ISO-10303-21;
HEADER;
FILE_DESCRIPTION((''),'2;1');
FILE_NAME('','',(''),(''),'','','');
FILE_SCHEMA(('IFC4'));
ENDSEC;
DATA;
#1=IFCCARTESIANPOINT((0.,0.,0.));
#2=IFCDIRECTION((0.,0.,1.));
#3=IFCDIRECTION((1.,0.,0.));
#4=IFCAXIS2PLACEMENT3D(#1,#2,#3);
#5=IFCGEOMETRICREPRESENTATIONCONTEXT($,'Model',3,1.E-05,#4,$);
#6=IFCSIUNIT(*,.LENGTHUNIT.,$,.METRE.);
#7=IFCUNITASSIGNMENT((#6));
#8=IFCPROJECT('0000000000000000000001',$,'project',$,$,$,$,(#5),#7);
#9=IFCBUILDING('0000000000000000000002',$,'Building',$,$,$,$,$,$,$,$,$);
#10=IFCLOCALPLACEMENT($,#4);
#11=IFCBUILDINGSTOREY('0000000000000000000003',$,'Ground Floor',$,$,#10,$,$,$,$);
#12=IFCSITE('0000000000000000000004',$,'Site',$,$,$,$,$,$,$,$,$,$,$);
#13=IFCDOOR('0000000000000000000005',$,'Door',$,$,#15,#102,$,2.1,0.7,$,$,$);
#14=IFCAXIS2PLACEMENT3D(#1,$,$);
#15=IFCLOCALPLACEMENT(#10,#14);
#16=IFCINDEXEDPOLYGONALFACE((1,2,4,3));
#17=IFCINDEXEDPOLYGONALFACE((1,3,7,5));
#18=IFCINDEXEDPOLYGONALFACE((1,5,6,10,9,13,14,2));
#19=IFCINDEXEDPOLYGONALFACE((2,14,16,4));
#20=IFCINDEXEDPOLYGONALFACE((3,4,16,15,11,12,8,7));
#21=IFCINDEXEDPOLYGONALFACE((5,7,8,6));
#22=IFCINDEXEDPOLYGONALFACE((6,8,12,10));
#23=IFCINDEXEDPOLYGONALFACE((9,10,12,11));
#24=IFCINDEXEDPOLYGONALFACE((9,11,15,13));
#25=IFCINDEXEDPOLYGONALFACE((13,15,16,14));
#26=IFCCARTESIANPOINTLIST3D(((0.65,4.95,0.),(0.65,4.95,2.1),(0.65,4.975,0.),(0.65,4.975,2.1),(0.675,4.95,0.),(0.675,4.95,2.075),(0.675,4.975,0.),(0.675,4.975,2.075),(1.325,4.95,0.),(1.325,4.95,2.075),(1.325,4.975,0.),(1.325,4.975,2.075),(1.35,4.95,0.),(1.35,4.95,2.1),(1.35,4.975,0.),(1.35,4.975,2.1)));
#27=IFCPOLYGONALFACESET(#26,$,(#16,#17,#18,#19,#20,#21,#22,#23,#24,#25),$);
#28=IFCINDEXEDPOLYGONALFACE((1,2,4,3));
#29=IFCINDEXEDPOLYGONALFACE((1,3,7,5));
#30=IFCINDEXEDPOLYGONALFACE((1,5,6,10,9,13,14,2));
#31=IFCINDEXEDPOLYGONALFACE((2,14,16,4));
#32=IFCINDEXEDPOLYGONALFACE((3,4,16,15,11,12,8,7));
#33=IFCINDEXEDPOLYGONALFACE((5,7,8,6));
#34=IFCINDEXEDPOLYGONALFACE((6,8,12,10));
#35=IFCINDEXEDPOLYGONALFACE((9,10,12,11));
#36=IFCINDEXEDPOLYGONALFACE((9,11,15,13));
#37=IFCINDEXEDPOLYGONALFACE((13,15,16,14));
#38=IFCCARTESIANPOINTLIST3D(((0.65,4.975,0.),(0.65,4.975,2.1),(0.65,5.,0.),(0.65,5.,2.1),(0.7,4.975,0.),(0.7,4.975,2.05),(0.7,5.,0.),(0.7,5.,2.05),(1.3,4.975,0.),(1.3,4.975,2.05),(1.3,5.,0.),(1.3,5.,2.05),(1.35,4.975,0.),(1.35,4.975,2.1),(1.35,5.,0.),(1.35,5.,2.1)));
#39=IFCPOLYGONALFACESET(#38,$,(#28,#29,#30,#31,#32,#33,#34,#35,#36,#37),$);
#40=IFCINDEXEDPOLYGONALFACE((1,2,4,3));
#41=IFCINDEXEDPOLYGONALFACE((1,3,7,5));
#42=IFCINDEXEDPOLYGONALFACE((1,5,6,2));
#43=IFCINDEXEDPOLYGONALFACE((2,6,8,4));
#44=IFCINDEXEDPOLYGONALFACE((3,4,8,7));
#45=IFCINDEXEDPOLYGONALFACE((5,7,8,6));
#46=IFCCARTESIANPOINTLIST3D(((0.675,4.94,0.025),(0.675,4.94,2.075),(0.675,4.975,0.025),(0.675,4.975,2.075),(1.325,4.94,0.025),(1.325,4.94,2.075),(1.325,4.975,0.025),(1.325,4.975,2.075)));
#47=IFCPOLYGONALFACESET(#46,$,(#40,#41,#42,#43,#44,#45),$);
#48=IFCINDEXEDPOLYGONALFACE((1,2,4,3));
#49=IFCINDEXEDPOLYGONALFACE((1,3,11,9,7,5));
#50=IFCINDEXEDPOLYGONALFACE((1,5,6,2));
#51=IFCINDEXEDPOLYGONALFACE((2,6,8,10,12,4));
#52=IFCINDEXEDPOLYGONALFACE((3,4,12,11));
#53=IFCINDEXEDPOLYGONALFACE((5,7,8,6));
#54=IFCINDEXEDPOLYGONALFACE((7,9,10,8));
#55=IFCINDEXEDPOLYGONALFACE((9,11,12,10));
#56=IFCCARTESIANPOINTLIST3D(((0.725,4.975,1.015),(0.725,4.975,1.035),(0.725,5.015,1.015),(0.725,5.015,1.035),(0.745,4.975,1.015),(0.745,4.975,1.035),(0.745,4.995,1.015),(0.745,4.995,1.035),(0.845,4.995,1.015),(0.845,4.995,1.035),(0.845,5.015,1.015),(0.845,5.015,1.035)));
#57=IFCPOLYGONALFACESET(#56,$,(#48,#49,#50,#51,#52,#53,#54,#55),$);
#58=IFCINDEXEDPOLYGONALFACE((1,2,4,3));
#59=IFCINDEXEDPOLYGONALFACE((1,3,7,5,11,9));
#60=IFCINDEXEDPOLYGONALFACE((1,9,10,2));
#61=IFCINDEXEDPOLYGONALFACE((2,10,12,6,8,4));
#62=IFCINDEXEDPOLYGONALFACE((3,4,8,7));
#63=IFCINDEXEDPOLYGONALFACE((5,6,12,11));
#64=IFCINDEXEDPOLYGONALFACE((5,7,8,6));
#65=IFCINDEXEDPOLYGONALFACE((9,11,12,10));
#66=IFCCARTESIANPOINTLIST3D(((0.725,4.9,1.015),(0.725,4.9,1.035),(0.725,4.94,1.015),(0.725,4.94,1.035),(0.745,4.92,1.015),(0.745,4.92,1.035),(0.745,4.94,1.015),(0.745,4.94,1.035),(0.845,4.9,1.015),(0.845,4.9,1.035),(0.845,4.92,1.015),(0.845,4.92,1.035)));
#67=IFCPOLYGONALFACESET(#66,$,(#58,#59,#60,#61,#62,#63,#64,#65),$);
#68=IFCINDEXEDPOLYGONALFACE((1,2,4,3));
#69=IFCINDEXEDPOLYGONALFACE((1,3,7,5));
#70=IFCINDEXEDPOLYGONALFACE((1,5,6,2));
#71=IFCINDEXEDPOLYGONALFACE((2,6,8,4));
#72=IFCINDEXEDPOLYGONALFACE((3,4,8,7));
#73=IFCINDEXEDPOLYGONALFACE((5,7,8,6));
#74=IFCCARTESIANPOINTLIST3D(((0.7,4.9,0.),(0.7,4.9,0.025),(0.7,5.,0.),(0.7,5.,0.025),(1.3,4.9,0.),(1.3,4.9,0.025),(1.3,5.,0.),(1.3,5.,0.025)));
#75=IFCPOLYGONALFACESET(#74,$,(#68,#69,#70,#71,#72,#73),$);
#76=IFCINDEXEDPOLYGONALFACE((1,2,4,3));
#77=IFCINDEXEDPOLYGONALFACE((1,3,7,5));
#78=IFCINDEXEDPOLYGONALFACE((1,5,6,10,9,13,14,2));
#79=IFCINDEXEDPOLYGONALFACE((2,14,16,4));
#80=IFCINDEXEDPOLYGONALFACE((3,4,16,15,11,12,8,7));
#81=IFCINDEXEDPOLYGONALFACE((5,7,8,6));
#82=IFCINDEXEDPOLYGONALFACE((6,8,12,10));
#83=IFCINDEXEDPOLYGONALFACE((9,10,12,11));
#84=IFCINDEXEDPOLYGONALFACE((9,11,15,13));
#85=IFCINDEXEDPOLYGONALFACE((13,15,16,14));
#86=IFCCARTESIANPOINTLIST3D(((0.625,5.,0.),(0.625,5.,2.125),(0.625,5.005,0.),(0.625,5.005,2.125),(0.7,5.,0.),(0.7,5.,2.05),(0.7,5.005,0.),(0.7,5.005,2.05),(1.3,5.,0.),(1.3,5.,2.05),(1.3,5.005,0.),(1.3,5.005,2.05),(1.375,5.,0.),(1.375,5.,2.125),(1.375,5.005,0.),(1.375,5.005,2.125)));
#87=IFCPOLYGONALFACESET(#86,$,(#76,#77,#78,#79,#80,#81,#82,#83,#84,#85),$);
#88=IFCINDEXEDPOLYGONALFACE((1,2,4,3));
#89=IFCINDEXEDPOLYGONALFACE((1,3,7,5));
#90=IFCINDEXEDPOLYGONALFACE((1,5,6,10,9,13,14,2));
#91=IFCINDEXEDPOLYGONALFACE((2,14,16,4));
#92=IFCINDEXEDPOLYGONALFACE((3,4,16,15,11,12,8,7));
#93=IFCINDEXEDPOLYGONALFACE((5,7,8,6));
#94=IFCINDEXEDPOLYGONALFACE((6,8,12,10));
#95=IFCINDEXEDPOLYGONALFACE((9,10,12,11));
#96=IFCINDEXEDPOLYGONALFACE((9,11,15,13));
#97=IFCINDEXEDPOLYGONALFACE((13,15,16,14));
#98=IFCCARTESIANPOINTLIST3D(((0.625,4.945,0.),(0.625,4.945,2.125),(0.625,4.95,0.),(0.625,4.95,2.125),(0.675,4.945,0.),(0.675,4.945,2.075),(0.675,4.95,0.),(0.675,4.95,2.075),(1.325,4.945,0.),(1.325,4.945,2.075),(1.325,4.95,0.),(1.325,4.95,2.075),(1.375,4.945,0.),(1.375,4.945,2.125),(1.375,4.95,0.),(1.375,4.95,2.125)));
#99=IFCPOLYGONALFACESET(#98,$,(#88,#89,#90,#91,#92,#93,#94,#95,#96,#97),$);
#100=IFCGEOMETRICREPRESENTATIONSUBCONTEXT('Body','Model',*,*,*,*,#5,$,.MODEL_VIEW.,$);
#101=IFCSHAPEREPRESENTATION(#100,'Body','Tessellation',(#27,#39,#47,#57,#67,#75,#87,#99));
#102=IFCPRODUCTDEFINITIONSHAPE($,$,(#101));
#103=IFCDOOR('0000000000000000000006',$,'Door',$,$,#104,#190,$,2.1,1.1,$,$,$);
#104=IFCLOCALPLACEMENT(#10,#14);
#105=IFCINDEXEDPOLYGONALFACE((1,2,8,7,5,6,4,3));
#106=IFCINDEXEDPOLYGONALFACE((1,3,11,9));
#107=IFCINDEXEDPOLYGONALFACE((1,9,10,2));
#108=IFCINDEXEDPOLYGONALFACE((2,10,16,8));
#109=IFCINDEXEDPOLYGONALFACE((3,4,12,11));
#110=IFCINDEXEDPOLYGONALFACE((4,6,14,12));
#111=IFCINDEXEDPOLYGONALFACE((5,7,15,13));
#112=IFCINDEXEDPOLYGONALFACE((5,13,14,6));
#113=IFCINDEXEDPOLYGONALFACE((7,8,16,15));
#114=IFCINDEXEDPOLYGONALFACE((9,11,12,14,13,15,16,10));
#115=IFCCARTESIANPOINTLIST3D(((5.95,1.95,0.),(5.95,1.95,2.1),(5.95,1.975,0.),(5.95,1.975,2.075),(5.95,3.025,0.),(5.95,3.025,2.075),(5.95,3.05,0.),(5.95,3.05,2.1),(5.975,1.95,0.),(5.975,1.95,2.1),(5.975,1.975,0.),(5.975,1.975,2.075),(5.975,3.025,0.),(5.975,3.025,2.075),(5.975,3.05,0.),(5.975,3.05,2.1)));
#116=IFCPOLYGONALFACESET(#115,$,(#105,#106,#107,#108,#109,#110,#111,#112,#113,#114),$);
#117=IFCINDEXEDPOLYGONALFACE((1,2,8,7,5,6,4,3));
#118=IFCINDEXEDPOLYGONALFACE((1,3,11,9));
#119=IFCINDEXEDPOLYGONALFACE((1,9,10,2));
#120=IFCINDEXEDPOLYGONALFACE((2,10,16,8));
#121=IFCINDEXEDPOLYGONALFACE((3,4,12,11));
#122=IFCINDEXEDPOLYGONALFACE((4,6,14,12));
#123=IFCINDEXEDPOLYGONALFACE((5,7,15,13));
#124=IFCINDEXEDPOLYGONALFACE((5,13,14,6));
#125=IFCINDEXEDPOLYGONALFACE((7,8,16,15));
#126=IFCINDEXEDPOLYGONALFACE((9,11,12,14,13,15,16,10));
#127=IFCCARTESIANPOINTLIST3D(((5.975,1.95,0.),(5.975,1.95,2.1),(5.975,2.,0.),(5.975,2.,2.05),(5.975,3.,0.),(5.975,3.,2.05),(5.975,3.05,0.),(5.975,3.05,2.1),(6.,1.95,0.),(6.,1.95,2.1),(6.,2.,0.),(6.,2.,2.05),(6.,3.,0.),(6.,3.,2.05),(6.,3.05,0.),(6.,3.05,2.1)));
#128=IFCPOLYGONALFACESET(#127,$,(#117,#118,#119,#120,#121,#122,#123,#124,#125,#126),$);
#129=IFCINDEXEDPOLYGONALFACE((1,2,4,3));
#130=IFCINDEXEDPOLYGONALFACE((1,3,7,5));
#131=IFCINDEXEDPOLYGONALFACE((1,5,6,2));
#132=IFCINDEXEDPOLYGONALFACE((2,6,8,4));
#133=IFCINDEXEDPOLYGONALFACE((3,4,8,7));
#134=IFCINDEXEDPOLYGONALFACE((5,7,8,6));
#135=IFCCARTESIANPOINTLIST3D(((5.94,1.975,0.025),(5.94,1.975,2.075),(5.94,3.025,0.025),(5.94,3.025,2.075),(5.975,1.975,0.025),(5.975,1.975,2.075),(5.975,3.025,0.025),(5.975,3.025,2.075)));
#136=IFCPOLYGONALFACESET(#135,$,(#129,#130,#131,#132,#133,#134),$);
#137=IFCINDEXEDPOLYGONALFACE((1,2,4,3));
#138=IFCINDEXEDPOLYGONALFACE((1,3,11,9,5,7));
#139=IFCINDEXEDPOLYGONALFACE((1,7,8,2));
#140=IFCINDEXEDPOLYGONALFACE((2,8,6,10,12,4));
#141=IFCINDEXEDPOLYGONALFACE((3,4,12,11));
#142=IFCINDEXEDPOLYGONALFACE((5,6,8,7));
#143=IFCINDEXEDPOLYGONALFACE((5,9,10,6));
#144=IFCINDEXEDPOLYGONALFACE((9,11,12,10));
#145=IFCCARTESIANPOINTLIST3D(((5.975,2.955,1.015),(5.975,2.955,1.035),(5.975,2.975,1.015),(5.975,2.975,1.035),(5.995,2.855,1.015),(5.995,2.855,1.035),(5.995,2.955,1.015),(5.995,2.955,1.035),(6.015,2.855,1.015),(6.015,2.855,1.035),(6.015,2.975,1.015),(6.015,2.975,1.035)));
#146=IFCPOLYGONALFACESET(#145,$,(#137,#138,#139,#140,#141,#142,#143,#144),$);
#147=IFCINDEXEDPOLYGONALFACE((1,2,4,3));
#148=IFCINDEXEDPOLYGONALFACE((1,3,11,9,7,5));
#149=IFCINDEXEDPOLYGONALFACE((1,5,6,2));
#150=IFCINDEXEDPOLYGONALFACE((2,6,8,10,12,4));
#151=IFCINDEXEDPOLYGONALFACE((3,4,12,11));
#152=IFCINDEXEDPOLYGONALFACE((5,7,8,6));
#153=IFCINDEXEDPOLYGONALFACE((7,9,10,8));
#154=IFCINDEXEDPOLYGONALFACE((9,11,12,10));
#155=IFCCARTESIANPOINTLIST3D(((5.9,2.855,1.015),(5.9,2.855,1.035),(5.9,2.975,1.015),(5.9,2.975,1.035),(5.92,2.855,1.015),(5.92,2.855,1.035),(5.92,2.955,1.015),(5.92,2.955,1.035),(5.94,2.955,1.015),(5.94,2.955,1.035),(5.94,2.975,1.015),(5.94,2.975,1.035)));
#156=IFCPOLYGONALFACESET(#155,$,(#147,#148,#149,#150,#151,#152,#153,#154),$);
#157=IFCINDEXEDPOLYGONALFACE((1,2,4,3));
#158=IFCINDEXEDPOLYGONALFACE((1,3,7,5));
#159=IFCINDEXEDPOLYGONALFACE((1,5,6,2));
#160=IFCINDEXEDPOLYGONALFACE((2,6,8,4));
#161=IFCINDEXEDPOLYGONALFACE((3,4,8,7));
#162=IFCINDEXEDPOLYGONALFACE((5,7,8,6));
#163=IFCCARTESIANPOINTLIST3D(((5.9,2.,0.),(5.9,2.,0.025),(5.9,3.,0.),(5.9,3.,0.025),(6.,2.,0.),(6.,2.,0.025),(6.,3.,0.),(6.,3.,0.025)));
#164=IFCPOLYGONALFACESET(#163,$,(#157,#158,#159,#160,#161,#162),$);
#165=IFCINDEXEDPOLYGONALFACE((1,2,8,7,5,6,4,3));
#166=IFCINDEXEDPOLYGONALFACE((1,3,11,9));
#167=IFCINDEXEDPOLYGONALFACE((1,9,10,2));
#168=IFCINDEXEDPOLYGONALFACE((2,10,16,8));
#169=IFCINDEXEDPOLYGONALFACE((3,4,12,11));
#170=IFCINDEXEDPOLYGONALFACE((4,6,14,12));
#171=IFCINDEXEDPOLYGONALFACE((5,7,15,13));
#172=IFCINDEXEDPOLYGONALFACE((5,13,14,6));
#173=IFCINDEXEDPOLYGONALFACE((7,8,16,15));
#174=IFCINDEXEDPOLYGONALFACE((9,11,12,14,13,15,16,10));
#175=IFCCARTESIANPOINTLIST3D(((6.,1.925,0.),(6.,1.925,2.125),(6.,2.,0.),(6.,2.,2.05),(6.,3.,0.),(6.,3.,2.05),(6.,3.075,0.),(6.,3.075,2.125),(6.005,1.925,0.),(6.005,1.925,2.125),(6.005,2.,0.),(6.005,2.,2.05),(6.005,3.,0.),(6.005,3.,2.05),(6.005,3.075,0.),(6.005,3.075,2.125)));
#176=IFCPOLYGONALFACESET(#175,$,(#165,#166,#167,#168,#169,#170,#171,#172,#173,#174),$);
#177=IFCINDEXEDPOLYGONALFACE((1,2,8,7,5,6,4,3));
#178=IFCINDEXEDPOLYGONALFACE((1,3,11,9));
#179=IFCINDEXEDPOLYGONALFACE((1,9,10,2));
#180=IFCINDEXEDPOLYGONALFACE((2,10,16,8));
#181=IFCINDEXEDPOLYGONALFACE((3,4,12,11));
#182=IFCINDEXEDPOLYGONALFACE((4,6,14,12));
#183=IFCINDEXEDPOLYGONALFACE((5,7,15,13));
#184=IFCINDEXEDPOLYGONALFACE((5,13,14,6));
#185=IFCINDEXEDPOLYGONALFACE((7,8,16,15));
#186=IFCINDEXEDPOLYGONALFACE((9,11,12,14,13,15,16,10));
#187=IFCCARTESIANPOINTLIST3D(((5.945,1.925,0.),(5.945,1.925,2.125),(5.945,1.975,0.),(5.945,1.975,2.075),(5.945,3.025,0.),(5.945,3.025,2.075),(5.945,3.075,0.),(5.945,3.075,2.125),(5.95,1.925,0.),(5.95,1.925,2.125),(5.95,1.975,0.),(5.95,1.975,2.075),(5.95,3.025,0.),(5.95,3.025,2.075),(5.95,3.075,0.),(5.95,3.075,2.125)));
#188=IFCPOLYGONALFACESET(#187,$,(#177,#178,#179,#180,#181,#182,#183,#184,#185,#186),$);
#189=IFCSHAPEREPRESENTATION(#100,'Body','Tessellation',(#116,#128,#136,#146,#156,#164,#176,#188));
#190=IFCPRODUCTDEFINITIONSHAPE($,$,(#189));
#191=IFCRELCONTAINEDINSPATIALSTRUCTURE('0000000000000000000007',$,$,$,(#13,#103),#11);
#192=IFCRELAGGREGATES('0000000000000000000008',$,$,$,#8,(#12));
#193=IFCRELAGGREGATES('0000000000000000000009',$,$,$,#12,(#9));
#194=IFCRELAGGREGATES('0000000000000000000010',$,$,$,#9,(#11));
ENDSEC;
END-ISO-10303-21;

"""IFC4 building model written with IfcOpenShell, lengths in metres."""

from ifc_helpers import new_model, si_unit, frame, origin_with_axes, place, context, subcontext, project, spatial, line, indexed_curve, outline, extrude, element, save


model = new_model("IFC4")

# Units and contexts
model_context = context("Model", 3, precision=1e-05, world=origin_with_axes())
body_context = subcontext(model_context, "Body", "Model", "MODEL_VIEW")
ifc_project = project(units=[si_unit("LENGTHUNIT", "METRE")], contexts=[model_context])

# Site, building, storey
site = spatial("IfcSite", under=ifc_project, Name="Site")
building = spatial("IfcBuilding", under=site, Name="Building")
storey_placement = place(None, origin_with_axes())
storey = spatial("IfcBuildingStorey", under=building, at=storey_placement, Name="Ground Floor")

# Doors
door_1_placement = place(storey_placement, frame((1.35, 5.0, 0.0), z_axis=(0.0, 0.0, 1.0), x_axis=(-1.0, 0.0, 0.0)))
element("IfcDoor", 1, at=door_1_placement, inside=storey, Name="Door", OverallHeight=2.1, OverallWidth=0.7, context=body_context, shape_type="SweptSolid", body=[
    extrude(outline(indexed_curve([(0.0, 0.0), (0.0, 2.1), (0.7, 2.1), (0.7, 0.0), (0.675, 0.0), (0.675, 2.075), (0.025, 2.075), (0.025, 0.0)], segments=[line(1, 2, 3, 4, 5, 6, 7, 8, 1)])), frame((0.0, 0.025, 0.0), z_axis=(0.0, -1.0, 0.0), x_axis=(1.0, 0.0, 0.0)), (0.0, 0.0, -1.0), 0.025),
    extrude(outline(indexed_curve([(0.0, 0.0), (0.0, 2.1), (0.7, 2.1), (0.7, 0.0), (0.65, 0.0), (0.65, 2.05), (0.05, 2.05), (0.05, 0.0)], segments=[line(1, 2, 3, 4, 5, 6, 7, 8, 1)])), frame((0.0, 0.0, 0.0), z_axis=(0.0, -1.0, 0.0), x_axis=(1.0, 0.0, 0.0)), (0.0, 0.0, -1.0), 0.025),
    extrude(outline(indexed_curve([(0.0, 0.0), (0.65, 0.0), (0.65, 0.035), (0.0, 0.035)], segments=[line(1, 2, 3, 4, 1)])), frame((0.025, 0.025, 0.025), z_axis=(0.0, 0.0, 1.0), x_axis=(1.0, 0.0, 0.0)), (0.0, 0.0, 1.0), 2.05),
    extrude(outline(indexed_curve([(0.0, 0.0), (0.0, -0.04), (-0.12, -0.04), (-0.12, -0.02), (-0.02, -0.02), (-0.02, 0.0)], segments=[line(1, 2, 3, 4, 5, 6, 1)])), frame((0.625, 0.025, 1.015), z_axis=(0.0, 0.0, 1.0), x_axis=(1.0, 0.0, 0.0)), (0.0, 0.0, 1.0), 0.02),
    extrude(outline(indexed_curve([(0.0, 0.0), (0.0, 0.04), (-0.12, 0.04), (-0.12, 0.02), (-0.02, 0.02), (-0.02, 0.0)], segments=[line(1, 2, 3, 4, 5, 6, 1)])), frame((0.625, 0.06, 1.015), z_axis=(0.0, 0.0, 1.0), x_axis=(1.0, 0.0, 0.0)), (0.0, 0.0, 1.0), 0.02),
    extrude(outline(indexed_curve([(0.0, 0.0), (0.6, 0.0), (0.6, 0.1), (0.0, 0.1)], segments=[line(1, 2, 3, 4, 1)])), frame((0.05, 0.0, 0.0), z_axis=(0.0, 0.0, 1.0), x_axis=(1.0, 0.0, 0.0)), (0.0, 0.0, 1.0), 0.025),
    extrude(outline(indexed_curve([(0.0, 0.0), (0.0, 2.125), (0.75, 2.125), (0.75, 0.0), (0.675, 0.0), (0.675, 2.05), (0.075, 2.05), (0.075, 0.0)], segments=[line(1, 2, 3, 4, 5, 6, 7, 8, 1)])), frame((-0.025, -0.005, 0.0), z_axis=(0.0, -1.0, 0.0), x_axis=(1.0, 0.0, 0.0)), (0.0, 0.0, -1.0), 0.005),
    extrude(outline(indexed_curve([(0.0, 0.0), (0.0, 2.125), (0.75, 2.125), (0.75, 0.0), (0.7, 0.0), (0.7, 2.075), (0.05, 2.075), (0.05, 0.0)], segments=[line(1, 2, 3, 4, 5, 6, 7, 8, 1)])), frame((-0.025, 0.05, 0.0), z_axis=(0.0, -1.0, 0.0), x_axis=(1.0, 0.0, 0.0)), (0.0, 0.0, -1.0), 0.005),
])
door_2_placement = place(storey_placement, frame((6.0, 1.95, 0.0), z_axis=(0.0, 0.0, 1.0), x_axis=(0.0, 1.0, 0.0)))
element("IfcDoor", 2, at=door_2_placement, inside=storey, Name="Door", OverallHeight=2.1, OverallWidth=1.1, context=body_context, shape_type="SweptSolid", body=[
    extrude(outline(indexed_curve([(0.0, 0.0), (0.0, 2.1), (1.1, 2.1), (1.1, 0.0), (1.075, 0.0), (1.075, 2.075), (0.025, 2.075), (0.025, 0.0)], segments=[line(1, 2, 3, 4, 5, 6, 7, 8, 1)])), frame((0.0, 0.025, 0.0), z_axis=(0.0, -1.0, 0.0), x_axis=(1.0, 0.0, 0.0)), (0.0, 0.0, -1.0), 0.025),
    extrude(outline(indexed_curve([(0.0, 0.0), (0.0, 2.1), (1.1, 2.1), (1.1, 0.0), (1.05, 0.0), (1.05, 2.05), (0.05, 2.05), (0.05, 0.0)], segments=[line(1, 2, 3, 4, 5, 6, 7, 8, 1)])), frame((0.0, 0.0, 0.0), z_axis=(0.0, -1.0, 0.0), x_axis=(1.0, 0.0, 0.0)), (0.0, 0.0, -1.0), 0.025),
    extrude(outline(indexed_curve([(0.0, 0.0), (1.05, 0.0), (1.05, 0.035), (0.0, 0.035)], segments=[line(1, 2, 3, 4, 1)])), frame((0.025, 0.025, 0.025), z_axis=(0.0, 0.0, 1.0), x_axis=(1.0, 0.0, 0.0)), (0.0, 0.0, 1.0), 2.05),
    extrude(outline(indexed_curve([(0.0, 0.0), (0.0, -0.04), (-0.12, -0.04), (-0.12, -0.02), (-0.02, -0.02), (-0.02, 0.0)], segments=[line(1, 2, 3, 4, 5, 6, 1)])), frame((1.025, 0.025, 1.015), z_axis=(0.0, 0.0, 1.0), x_axis=(1.0, 0.0, 0.0)), (0.0, 0.0, 1.0), 0.02),
    extrude(outline(indexed_curve([(0.0, 0.0), (0.0, 0.04), (-0.12, 0.04), (-0.12, 0.02), (-0.02, 0.02), (-0.02, 0.0)], segments=[line(1, 2, 3, 4, 5, 6, 1)])), frame((1.025, 0.06, 1.015), z_axis=(0.0, 0.0, 1.0), x_axis=(1.0, 0.0, 0.0)), (0.0, 0.0, 1.0), 0.02),
    extrude(outline(indexed_curve([(0.0, 0.0), (1.0, 0.0), (1.0, 0.1), (0.0, 0.1)], segments=[line(1, 2, 3, 4, 1)])), frame((0.05, 0.0, 0.0), z_axis=(0.0, 0.0, 1.0), x_axis=(1.0, 0.0, 0.0)), (0.0, 0.0, 1.0), 0.025),
    extrude(outline(indexed_curve([(0.0, 0.0), (0.0, 2.125), (1.15, 2.125), (1.15, 0.0), (1.075, 0.0), (1.075, 2.05), (0.075, 2.05), (0.075, 0.0)], segments=[line(1, 2, 3, 4, 5, 6, 7, 8, 1)])), frame((-0.025, -0.005, 0.0), z_axis=(0.0, -1.0, 0.0), x_axis=(1.0, 0.0, 0.0)), (0.0, 0.0, -1.0), 0.005),
    extrude(outline(indexed_curve([(0.0, 0.0), (0.0, 2.125), (1.15, 2.125), (1.15, 0.0), (1.1, 0.0), (1.1, 2.075), (0.05, 2.075), (0.05, 0.0)], segments=[line(1, 2, 3, 4, 5, 6, 7, 8, 1)])), frame((-0.025, 0.05, 0.0), z_axis=(0.0, -1.0, 0.0), x_axis=(1.0, 0.0, 0.0)), (0.0, 0.0, -1.0), 0.005),
])

save(model, "model.ifc")
